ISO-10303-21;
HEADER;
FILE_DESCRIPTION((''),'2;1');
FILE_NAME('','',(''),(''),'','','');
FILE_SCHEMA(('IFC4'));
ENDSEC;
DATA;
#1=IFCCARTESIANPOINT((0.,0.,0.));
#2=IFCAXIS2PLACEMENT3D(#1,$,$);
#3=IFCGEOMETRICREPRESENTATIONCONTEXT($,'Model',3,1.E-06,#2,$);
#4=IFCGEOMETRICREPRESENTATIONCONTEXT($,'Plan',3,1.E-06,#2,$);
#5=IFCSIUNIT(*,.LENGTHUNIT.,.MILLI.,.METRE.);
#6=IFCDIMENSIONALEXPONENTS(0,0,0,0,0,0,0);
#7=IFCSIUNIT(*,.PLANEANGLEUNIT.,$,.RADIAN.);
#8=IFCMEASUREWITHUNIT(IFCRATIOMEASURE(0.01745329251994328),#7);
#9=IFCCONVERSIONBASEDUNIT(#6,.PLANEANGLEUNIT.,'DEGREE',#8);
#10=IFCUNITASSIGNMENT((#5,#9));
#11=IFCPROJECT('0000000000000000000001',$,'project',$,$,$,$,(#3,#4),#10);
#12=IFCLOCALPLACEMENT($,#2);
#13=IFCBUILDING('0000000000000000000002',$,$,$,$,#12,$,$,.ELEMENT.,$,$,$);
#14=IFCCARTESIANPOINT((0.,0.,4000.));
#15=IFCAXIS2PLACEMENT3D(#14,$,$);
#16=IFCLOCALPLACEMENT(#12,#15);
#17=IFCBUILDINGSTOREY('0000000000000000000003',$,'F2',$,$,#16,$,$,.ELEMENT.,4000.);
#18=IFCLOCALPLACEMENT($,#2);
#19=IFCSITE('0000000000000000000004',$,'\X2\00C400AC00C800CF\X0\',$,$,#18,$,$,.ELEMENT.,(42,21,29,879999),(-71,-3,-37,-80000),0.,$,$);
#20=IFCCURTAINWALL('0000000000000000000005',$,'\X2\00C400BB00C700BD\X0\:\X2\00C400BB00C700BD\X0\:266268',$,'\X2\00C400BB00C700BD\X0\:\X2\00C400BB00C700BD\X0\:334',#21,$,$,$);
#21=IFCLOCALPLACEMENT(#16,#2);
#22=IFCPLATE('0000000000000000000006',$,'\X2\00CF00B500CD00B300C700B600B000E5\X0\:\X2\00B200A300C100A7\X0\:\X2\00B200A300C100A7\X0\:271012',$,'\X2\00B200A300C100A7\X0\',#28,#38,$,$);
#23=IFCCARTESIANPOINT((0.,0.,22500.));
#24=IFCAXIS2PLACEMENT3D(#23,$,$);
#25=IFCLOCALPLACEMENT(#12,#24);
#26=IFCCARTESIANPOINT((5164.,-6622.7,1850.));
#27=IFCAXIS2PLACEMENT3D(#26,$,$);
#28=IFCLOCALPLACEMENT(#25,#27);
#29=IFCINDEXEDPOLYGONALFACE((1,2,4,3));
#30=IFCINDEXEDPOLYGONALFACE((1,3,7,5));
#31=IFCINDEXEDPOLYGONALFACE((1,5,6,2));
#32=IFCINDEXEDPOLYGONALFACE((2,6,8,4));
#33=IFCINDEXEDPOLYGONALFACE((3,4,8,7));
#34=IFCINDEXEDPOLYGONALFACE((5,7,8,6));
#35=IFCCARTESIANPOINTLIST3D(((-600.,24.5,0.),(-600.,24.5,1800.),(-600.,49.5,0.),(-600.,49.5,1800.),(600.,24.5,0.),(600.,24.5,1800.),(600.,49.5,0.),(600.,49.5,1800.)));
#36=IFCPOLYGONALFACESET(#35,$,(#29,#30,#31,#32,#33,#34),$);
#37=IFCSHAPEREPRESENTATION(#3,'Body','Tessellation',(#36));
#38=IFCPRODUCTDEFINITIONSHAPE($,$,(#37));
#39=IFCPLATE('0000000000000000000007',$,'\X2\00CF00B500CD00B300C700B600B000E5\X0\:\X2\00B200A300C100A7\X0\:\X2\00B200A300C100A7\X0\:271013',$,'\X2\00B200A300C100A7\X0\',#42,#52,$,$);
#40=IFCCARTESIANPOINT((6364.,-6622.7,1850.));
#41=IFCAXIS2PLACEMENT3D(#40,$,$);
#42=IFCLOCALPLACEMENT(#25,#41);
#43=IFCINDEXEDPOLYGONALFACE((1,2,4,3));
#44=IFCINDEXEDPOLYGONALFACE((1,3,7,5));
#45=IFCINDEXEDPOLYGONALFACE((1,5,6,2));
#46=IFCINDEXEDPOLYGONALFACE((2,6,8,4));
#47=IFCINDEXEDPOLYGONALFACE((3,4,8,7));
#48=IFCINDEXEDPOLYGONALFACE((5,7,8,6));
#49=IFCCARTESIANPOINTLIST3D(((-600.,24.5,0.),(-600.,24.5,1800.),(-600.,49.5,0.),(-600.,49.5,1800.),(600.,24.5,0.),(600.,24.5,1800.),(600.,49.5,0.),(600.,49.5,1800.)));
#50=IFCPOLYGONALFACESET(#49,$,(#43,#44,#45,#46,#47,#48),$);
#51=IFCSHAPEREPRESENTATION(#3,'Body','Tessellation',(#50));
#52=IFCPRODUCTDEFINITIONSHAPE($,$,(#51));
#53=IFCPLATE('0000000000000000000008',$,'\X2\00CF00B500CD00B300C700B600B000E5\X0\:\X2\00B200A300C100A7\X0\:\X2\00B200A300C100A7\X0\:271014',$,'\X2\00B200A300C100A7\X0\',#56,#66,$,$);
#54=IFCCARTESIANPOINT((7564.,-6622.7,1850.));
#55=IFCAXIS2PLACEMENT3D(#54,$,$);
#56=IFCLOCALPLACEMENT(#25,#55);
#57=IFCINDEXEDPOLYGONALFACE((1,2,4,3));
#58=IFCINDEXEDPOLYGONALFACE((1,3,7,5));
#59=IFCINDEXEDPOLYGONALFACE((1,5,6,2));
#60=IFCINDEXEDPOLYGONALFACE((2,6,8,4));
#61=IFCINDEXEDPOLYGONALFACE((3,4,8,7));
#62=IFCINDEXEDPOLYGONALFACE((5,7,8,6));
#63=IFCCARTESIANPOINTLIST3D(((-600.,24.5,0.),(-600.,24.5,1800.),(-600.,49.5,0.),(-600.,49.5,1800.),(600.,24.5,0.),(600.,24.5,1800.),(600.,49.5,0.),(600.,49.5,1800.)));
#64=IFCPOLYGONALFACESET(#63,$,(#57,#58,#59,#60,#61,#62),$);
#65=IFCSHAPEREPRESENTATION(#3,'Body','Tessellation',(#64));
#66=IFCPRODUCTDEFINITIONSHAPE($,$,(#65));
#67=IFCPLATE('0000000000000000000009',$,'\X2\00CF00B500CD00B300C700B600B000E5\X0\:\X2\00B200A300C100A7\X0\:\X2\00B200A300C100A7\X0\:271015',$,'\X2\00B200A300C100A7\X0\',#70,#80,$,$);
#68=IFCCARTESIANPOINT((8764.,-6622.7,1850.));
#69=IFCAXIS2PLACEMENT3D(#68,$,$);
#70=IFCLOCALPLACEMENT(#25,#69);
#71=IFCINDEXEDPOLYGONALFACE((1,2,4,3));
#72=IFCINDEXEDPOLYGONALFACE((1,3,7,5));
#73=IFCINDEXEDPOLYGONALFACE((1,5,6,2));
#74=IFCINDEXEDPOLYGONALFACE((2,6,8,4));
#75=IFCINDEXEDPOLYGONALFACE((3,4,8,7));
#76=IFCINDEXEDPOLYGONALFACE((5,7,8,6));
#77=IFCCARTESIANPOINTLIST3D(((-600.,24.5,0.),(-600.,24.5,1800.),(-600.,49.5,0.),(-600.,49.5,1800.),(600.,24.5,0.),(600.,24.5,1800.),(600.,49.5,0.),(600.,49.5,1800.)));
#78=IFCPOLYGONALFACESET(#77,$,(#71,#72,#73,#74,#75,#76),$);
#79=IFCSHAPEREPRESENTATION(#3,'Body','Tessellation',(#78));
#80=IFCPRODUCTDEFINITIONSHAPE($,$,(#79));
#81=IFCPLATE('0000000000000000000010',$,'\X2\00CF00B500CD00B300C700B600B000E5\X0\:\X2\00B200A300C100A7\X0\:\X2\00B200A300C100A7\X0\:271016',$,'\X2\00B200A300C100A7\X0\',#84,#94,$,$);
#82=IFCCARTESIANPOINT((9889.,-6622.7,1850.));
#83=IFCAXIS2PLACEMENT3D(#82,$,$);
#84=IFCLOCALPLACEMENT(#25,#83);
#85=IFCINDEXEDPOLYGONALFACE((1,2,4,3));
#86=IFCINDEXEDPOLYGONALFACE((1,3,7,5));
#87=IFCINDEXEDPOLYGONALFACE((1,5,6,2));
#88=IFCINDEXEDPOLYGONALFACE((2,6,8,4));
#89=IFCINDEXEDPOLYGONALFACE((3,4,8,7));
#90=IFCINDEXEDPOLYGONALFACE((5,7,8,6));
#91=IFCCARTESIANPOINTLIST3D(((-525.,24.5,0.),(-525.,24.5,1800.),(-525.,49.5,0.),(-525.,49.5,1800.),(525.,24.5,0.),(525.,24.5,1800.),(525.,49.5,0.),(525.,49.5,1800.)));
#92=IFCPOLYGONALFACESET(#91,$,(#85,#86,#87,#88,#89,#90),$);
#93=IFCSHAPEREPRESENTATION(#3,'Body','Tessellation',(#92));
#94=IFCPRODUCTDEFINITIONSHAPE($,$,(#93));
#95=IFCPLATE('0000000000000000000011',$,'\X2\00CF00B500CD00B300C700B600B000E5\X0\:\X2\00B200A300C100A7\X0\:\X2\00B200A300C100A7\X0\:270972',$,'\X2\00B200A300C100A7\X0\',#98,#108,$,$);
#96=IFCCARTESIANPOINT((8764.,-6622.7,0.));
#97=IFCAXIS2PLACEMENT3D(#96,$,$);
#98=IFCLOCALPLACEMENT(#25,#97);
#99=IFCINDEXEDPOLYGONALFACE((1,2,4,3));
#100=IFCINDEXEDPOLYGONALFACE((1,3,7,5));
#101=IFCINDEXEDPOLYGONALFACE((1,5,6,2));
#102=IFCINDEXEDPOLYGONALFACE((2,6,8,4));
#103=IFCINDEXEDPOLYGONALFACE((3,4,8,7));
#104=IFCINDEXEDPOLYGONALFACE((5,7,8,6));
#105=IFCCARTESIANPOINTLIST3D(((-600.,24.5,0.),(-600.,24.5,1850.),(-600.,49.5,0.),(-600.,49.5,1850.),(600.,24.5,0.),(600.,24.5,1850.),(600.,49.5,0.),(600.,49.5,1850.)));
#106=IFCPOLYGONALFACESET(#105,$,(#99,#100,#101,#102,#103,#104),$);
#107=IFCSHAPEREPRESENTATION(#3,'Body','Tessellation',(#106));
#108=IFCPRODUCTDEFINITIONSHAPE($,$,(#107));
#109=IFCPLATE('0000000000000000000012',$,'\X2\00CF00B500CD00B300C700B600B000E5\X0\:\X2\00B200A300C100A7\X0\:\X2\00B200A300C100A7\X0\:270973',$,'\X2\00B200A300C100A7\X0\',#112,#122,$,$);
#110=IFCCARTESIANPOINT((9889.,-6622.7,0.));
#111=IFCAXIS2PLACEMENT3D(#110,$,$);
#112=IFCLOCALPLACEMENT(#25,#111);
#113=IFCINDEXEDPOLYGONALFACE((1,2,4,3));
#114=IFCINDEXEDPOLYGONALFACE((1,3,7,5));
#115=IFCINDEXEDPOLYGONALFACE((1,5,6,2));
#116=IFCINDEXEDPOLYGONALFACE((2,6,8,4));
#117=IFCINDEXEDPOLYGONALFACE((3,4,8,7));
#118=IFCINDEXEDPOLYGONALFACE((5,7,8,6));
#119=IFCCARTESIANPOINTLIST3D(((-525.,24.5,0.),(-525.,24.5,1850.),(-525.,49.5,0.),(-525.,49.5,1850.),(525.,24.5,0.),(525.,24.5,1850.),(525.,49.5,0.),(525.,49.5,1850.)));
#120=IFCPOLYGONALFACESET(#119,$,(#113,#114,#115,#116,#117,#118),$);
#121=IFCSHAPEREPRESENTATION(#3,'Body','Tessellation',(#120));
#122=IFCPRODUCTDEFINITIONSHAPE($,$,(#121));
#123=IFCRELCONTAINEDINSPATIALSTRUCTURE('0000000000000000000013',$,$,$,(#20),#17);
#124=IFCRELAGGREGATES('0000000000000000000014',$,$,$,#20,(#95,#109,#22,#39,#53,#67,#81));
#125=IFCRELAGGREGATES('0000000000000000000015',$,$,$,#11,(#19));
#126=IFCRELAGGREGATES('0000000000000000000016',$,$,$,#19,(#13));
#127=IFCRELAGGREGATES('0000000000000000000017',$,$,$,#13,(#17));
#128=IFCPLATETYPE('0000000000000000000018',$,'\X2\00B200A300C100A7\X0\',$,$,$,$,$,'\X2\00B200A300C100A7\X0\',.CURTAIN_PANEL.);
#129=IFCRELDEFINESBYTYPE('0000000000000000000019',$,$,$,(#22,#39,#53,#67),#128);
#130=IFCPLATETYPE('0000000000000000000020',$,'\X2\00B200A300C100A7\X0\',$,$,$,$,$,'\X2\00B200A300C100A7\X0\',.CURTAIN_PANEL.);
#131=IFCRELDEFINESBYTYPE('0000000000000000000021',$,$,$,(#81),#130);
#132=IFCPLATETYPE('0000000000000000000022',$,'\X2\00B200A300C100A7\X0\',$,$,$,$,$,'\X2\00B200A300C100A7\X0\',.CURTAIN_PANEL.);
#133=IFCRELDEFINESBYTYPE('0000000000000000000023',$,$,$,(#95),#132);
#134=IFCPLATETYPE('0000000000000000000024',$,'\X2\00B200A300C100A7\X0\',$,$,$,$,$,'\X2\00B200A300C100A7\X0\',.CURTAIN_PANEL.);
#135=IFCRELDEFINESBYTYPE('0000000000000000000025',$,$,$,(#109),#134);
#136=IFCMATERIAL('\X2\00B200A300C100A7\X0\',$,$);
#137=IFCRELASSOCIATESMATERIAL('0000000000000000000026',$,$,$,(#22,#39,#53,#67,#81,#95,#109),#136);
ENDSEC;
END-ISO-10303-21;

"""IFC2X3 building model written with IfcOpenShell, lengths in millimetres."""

from ifc_helpers import new_model, entity, si_unit, converted_unit, frame, origin, origin_2d_with_axis, place, context, project, spatial, rectangle, extrude, source, transform, mapped, material, type_object, type_shapes, element, aggregate, save


model = new_model("IFC2X3")

# Units and contexts
model_context = context("Model", 3, precision=1e-06, world=origin())
plan_context = context("Plan", 3, precision=1e-06, world=origin())
ifc_project = project(units=[si_unit("LENGTHUNIT", "METRE", prefix="MILLI"), converted_unit("PLANEANGLEUNIT", "DEGREE", entity("IfcRatioMeasure", 0.01745329251994328), si_unit("PLANEANGLEUNIT", "RADIAN"), dimensions=[0, 0, 0, 0, 0, 0, 0])], contexts=[model_context, plan_context])

# Site, building, storey
site_placement = place(None, origin())
site = spatial("IfcSite", under=ifc_project, at=site_placement, Name="Ä¬ÈÏ", CompositionType="ELEMENT", RefLatitude=(42, 21, 29, 879999), RefLongitude=(-71, -3, -37, -80000), RefElevation=0.0)
building_placement = place(None, origin())
building = spatial("IfcBuilding", under=site, at=building_placement, CompositionType="ELEMENT")
storey_placement = place(building_placement, frame((0.0, 0.0, 4000.0)))
storey = spatial("IfcBuildingStorey", under=building, at=storey_placement, Name="F2", CompositionType="ELEMENT", Elevation=4000.0)

# Curtain wall, plates
curtain_wall_placement = place(storey_placement, origin())
curtain_wall = element("IfcCurtainWall", 1, at=curtain_wall_placement, inside=storey, Name="Ä»Ç½:Ä»Ç½:266268", ObjectType="Ä»Ç½:Ä»Ç½:334")
placement_1 = place(building_placement, frame((0.0, 0.0, 22500.0)))
ifc_material_1 = material(Name="²£Á§")
plate_type_1 = type_object("IfcPlateType", Name="²£Á§", ElementType="²£Á§", PredefinedType="CURTAIN_PANEL")
shared_shape_1 = source(origin(), model_context, "Body", "SweptSolid", [
    extrude(rectangle(XDim=25.0, YDim=1200.0, at=origin_2d_with_axis()), frame((0.0, 37.0, 0.0), z_axis=(0.0, 0.0, 1.0), x_axis=(0.0, 1.0, 0.0)), (0.0, 0.0, 1.0), 1800.0),
])
type_shapes(plate_type_1, [shared_shape_1])
plate_1_placement = place(placement_1, frame((5164.0, -6622.7, 1850.0)))
plate_1 = element("IfcPlate", 2, at=plate_1_placement, type_object=plate_type_1, material=ifc_material_1, Name="ÏµÍ³Ç¶°å:²£Á§:²£Á§:271012", ObjectType="²£Á§", context=model_context, shape_type="MappedRepresentation", body=[
    mapped(shared_shape_1, transform((0.0, 0.0, 0.0), scale=1.0)),
])
plate_2_placement = place(placement_1, frame((6364.0, -6622.7, 1850.0)))
plate_2 = element("IfcPlate", 3, at=plate_2_placement, type_object=plate_type_1, material=ifc_material_1, Name="ÏµÍ³Ç¶°å:²£Á§:²£Á§:271013", ObjectType="²£Á§", context=model_context, shape_type="MappedRepresentation", body=[
    mapped(shared_shape_1, transform((0.0, 0.0, 0.0), scale=1.0)),
])
plate_3_placement = place(placement_1, frame((7564.0, -6622.7, 1850.0)))
plate_3 = element("IfcPlate", 4, at=plate_3_placement, type_object=plate_type_1, material=ifc_material_1, Name="ÏµÍ³Ç¶°å:²£Á§:²£Á§:271014", ObjectType="²£Á§", context=model_context, shape_type="MappedRepresentation", body=[
    mapped(shared_shape_1, transform((0.0, 0.0, 0.0), scale=1.0)),
])
plate_4_placement = place(placement_1, frame((8764.0, -6622.7, 1850.0)))
plate_4 = element("IfcPlate", 5, at=plate_4_placement, type_object=plate_type_1, material=ifc_material_1, Name="ÏµÍ³Ç¶°å:²£Á§:²£Á§:271015", ObjectType="²£Á§", context=model_context, shape_type="MappedRepresentation", body=[
    mapped(shared_shape_1, transform((0.0, 0.0, 0.0), scale=1.0)),
])
plate_type_2 = type_object("IfcPlateType", Name="²£Á§", ElementType="²£Á§", PredefinedType="CURTAIN_PANEL")
shared_shape_2 = source(origin(), model_context, "Body", "SweptSolid", [
    extrude(rectangle(XDim=25.0, YDim=1050.0, at=origin_2d_with_axis()), frame((0.0, 37.0, 0.0), z_axis=(0.0, 0.0, 1.0), x_axis=(0.0, 1.0, 0.0)), (0.0, 0.0, 1.0), 1800.0),
])
type_shapes(plate_type_2, [shared_shape_2])
plate_5_placement = place(placement_1, frame((9889.0, -6622.7, 1850.0)))
plate_5 = element("IfcPlate", 6, at=plate_5_placement, type_object=plate_type_2, material=ifc_material_1, Name="ÏµÍ³Ç¶°å:²£Á§:²£Á§:271016", ObjectType="²£Á§", context=model_context, shape_type="MappedRepresentation", body=[
    mapped(shared_shape_2, transform((0.0, 0.0, 0.0), scale=1.0)),
])
plate_type_3 = type_object("IfcPlateType", Name="²£Á§", ElementType="²£Á§", PredefinedType="CURTAIN_PANEL")
shared_shape_3 = source(origin(), model_context, "Body", "SweptSolid", [
    extrude(rectangle(XDim=25.0, YDim=1200.0, at=origin_2d_with_axis()), frame((0.0, 37.0, 0.0), z_axis=(0.0, 0.0, 1.0), x_axis=(0.0, 1.0, 0.0)), (0.0, 0.0, 1.0), 1850.0),
])
type_shapes(plate_type_3, [shared_shape_3])
plate_6_placement = place(placement_1, frame((8764.0, -6622.7, 0.0)))
plate_6 = element("IfcPlate", 7, at=plate_6_placement, type_object=plate_type_3, material=ifc_material_1, Name="ÏµÍ³Ç¶°å:²£Á§:²£Á§:270972", ObjectType="²£Á§", context=model_context, shape_type="MappedRepresentation", body=[
    mapped(shared_shape_3, transform((0.0, 0.0, 0.0), scale=1.0)),
])
plate_type_4 = type_object("IfcPlateType", Name="²£Á§", ElementType="²£Á§", PredefinedType="CURTAIN_PANEL")
shared_shape_4 = source(origin(), model_context, "Body", "SweptSolid", [
    extrude(rectangle(XDim=25.0, YDim=1050.0, at=origin_2d_with_axis()), frame((0.0, 37.0, 0.0), z_axis=(0.0, 0.0, 1.0), x_axis=(0.0, 1.0, 0.0)), (0.0, 0.0, 1.0), 1850.0),
])
type_shapes(plate_type_4, [shared_shape_4])
plate_7_placement = place(placement_1, frame((9889.0, -6622.7, 0.0)))
plate_7 = element("IfcPlate", 8, at=plate_7_placement, type_object=plate_type_4, material=ifc_material_1, Name="ÏµÍ³Ç¶°å:²£Á§:²£Á§:270973", ObjectType="²£Á§", context=model_context, shape_type="MappedRepresentation", body=[
    mapped(shared_shape_4, transform((0.0, 0.0, 0.0), scale=1.0)),
])
aggregate(curtain_wall, [plate_6, plate_7, plate_1, plate_2, plate_3, plate_4, plate_5])

save(model, "model.ifc")
